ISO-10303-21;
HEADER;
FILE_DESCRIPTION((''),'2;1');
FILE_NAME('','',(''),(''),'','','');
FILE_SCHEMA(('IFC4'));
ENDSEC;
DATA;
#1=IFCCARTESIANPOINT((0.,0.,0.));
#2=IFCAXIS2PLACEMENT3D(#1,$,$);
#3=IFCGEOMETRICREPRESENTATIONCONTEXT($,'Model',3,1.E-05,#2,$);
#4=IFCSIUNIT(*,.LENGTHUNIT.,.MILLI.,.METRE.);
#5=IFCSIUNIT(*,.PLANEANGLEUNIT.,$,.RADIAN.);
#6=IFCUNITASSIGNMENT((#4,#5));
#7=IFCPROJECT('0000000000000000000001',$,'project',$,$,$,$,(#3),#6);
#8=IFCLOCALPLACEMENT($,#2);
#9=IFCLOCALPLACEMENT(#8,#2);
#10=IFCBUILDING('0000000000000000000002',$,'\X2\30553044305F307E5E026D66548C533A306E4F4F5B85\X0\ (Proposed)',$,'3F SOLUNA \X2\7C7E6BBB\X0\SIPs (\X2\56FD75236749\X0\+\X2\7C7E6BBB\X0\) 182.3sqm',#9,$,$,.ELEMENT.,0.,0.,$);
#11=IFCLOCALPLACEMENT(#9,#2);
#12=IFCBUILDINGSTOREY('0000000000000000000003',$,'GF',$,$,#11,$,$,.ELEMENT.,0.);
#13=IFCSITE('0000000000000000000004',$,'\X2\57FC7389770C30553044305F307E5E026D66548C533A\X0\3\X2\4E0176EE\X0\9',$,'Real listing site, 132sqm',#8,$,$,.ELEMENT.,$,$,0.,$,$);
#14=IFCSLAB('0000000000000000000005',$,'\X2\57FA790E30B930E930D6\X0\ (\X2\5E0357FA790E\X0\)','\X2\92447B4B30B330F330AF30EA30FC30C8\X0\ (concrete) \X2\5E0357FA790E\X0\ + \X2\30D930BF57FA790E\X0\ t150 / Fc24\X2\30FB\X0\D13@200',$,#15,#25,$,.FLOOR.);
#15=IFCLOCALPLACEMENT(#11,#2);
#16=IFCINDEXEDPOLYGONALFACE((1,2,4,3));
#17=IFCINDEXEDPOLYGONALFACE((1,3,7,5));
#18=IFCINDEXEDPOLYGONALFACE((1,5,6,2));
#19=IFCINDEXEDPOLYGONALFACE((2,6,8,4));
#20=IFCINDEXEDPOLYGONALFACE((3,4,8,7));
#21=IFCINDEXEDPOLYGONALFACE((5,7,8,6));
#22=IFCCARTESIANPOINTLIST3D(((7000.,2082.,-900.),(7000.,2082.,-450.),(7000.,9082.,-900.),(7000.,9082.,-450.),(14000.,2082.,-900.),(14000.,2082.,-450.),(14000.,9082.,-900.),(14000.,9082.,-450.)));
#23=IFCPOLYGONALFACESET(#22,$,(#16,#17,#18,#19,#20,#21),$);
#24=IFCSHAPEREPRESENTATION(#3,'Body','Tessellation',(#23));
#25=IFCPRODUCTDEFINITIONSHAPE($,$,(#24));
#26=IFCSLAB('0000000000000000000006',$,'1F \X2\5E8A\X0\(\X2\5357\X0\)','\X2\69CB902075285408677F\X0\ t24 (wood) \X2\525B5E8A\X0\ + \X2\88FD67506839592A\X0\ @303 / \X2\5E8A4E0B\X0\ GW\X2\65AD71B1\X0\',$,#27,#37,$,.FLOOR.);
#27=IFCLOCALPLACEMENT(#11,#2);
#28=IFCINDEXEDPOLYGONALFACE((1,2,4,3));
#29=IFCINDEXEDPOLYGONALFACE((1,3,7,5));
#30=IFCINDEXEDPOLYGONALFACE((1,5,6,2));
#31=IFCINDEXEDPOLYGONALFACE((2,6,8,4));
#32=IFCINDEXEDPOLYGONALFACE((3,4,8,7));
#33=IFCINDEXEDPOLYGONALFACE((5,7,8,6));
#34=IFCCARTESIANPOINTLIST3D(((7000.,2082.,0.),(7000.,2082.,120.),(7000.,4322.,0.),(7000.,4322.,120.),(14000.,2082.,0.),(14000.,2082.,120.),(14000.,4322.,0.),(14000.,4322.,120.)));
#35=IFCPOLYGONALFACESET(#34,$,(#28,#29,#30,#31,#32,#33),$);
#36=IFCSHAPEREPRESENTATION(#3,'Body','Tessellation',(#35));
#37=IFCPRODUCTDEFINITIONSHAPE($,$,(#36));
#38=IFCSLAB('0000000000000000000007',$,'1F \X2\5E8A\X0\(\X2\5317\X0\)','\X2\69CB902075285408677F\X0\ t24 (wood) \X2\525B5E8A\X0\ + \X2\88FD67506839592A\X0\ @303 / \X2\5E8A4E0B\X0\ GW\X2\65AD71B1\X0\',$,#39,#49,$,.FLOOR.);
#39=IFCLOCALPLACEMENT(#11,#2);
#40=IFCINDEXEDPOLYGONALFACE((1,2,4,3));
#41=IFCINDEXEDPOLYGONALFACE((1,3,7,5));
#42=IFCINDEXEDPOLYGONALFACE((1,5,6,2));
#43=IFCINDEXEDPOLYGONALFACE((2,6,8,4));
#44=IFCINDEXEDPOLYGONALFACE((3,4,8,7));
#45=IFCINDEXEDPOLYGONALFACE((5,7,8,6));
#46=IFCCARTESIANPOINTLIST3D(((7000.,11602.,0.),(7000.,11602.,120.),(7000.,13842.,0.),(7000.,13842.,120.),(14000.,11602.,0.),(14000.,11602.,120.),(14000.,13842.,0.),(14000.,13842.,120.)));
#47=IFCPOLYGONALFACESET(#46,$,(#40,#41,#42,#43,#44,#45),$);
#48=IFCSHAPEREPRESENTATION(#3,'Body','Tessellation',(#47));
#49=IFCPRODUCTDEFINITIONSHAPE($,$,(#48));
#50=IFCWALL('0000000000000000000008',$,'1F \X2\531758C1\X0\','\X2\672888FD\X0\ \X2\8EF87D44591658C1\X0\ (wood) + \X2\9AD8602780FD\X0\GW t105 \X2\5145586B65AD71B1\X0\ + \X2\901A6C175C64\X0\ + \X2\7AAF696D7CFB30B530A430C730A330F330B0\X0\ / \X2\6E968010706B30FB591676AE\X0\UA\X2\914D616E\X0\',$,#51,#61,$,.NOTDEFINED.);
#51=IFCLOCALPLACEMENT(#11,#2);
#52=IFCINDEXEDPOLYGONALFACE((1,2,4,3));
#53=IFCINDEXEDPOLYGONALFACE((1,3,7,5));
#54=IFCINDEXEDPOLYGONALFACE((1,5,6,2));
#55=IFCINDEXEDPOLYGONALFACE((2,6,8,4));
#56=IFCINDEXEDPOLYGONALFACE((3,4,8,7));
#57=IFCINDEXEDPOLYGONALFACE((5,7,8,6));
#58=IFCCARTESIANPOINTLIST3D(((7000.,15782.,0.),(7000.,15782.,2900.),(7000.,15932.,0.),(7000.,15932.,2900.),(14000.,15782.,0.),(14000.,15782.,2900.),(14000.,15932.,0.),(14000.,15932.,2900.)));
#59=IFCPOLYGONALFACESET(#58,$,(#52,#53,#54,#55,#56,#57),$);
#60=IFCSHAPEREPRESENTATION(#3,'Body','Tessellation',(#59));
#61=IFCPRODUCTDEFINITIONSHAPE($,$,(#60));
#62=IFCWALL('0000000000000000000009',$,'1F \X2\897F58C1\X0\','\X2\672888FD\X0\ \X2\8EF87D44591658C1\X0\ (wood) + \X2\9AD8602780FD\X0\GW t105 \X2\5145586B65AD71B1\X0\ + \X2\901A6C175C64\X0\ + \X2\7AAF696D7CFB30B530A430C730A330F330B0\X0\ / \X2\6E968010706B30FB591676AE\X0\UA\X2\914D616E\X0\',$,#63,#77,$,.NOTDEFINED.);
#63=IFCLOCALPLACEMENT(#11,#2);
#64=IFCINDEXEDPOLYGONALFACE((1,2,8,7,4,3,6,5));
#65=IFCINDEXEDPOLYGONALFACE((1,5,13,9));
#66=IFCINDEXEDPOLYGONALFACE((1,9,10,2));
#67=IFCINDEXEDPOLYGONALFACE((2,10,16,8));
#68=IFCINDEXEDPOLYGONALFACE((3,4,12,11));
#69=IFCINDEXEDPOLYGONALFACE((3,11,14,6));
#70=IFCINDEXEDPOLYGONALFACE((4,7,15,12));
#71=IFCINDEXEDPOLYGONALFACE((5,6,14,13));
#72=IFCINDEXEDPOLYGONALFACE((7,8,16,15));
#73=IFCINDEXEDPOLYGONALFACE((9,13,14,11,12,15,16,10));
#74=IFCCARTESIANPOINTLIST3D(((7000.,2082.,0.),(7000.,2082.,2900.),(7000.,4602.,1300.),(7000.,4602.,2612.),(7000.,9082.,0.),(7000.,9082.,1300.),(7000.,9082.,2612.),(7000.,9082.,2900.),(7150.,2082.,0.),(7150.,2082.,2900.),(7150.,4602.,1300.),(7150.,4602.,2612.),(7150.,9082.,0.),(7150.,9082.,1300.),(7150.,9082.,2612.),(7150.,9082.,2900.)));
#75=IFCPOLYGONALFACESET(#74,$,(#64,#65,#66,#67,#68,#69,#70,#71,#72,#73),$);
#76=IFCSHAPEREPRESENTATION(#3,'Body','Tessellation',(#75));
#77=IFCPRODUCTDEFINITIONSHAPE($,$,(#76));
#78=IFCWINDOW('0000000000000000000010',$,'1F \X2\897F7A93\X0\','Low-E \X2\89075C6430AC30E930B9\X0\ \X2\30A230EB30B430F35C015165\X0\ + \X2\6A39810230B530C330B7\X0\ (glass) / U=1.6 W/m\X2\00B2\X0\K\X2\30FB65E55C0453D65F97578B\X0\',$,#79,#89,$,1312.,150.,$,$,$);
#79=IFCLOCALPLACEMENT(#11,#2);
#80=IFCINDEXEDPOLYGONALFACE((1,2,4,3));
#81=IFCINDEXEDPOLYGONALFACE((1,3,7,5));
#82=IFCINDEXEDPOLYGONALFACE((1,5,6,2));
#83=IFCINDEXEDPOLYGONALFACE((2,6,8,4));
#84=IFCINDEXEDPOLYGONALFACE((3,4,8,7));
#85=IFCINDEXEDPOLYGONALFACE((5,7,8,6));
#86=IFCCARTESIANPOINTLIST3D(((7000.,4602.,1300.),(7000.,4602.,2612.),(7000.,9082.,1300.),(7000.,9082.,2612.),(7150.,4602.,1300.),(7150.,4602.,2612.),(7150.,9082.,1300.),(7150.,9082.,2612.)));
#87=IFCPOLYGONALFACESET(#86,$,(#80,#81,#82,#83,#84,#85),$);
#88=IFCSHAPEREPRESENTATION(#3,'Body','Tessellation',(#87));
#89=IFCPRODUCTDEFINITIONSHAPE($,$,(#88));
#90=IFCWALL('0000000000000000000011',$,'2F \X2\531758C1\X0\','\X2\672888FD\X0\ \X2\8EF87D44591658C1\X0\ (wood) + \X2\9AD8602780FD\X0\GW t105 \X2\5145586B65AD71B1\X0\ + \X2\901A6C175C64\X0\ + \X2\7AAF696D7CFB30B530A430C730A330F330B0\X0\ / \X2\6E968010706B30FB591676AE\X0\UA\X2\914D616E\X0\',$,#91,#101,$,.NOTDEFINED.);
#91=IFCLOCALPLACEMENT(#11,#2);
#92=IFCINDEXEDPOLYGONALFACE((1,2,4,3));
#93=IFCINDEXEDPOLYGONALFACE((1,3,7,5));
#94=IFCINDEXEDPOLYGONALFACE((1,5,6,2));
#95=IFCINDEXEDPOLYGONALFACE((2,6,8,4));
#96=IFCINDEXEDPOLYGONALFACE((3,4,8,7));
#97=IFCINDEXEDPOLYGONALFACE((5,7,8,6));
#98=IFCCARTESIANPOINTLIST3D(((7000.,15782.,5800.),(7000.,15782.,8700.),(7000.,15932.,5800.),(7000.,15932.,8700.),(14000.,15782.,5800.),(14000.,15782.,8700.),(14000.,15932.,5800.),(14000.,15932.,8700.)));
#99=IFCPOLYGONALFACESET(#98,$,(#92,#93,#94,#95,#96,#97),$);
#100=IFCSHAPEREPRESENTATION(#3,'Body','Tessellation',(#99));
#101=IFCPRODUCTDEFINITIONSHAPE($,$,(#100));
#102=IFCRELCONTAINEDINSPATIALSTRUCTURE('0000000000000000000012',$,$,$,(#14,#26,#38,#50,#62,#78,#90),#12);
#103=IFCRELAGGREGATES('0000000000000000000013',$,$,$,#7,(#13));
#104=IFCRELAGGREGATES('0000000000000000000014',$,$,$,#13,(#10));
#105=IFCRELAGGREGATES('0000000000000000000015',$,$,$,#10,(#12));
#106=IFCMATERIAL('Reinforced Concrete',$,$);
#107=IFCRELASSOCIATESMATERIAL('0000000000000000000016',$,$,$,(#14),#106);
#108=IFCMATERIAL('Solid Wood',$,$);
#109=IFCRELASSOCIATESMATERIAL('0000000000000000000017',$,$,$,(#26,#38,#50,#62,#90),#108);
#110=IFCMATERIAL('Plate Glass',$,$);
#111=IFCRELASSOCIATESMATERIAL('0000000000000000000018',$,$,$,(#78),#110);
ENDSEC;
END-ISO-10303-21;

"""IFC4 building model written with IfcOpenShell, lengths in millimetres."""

from ifc_helpers import new_model, si_unit, frame, frame_2d, origin, place, context, project, spatial, rectangle, extrude, material, element, fill, save


model = new_model("IFC4")

# Units and contexts
model_context = context("Model", 3, precision=1e-05, world=origin())
ifc_project = project(units=[si_unit("LENGTHUNIT", "METRE", prefix="MILLI"), si_unit("PLANEANGLEUNIT", "RADIAN")], contexts=[model_context])

# Site, building, storey
site_placement = place(None, origin())
site = spatial("IfcSite", under=ifc_project, at=site_placement, Name="埼玉県さいたま市浦和区3丁目9", ObjectType="Real listing site, 132sqm", CompositionType="ELEMENT", RefElevation=0.0)
building_placement = place(site_placement, origin())
building = spatial("IfcBuilding", under=site, at=building_placement, Name="さいたま市浦和区の住宅 (Proposed)", ObjectType="3F SOLUNA 籾殻SIPs (国産杉+籾殻) 182.3sqm", CompositionType="ELEMENT", ElevationOfRefHeight=0.0, ElevationOfTerrain=0.0)
storey_placement = place(building_placement, origin())
storey = spatial("IfcBuildingStorey", under=building, at=storey_placement, Name="GF", CompositionType="ELEMENT", Elevation=0.0)

# Slabs
ifc_material_1 = material(Name="Reinforced Concrete")
slab_1_placement = place(storey_placement, frame((3500.0, 1041.0, -450.0)))
element("IfcSlab", 1, at=slab_1_placement, inside=storey, material=ifc_material_1, Name="基礎スラブ (布基礎)", Description="鉄筋コンクリート (concrete) 布基礎 + ベタ基礎 t150 / Fc24・D13@200", PredefinedType="FLOOR", context=model_context, shape_type="SweptSolid", body=[
    extrude(rectangle(XDim=7000.0, YDim=7000.0, at=frame_2d((3500.0, 3500.0))), frame((3500.0, 1041.0, -450.0)), (0.0, 0.0, 1.0), 450.0),
])
ifc_material_2 = material(Name="Solid Wood")
slab_2_placement = place(storey_placement, frame((3500.0, 1041.0, 0.0)))
element("IfcSlab", 2, at=slab_2_placement, inside=storey, material=ifc_material_2, Name="1F 床(南)", Description="構造用合板 t24 (wood) 剛床 + 製材根太 @303 / 床下 GW断熱", PredefinedType="FLOOR", context=model_context, shape_type="SweptSolid", body=[
    extrude(rectangle(XDim=7000.0, YDim=2240.0, at=frame_2d((3500.0, 1120.0))), frame((3500.0, 1041.0, 0.0)), (0.0, 0.0, 1.0), 120.0),
])
slab_3_placement = place(storey_placement, frame((3500.0, 5801.0, 0.0)))
element("IfcSlab", 3, at=slab_3_placement, inside=storey, material=ifc_material_2, Name="1F 床(北)", Description="構造用合板 t24 (wood) 剛床 + 製材根太 @303 / 床下 GW断熱", PredefinedType="FLOOR", context=model_context, shape_type="SweptSolid", body=[
    extrude(rectangle(XDim=7000.0, YDim=2240.0, at=frame_2d((3500.0, 1120.0))), frame((3500.0, 5801.0, 0.0)), (0.0, 0.0, 1.0), 120.0),
])

# Shared definitions
ifc_material_3 = material(Name="Plate Glass")

# Wall
wall_1_placement = place(storey_placement, frame((3500.0, 7891.0, 0.0)))
element("IfcWall", 4, at=wall_1_placement, inside=storey, material=ifc_material_2, Name="1F 北壁", Description="木製 軸組外壁 (wood) + 高性能GW t105 充填断熱 + 通気層 + 窯業系サイディング / 準耐火・外皮UA配慮", PredefinedType="NOTDEFINED", context=model_context, shape_type="SweptSolid", body=[
    extrude(rectangle(XDim=7000.0, YDim=150.0, at=frame_2d((3500.0, 75.0))), frame((3500.0, 7891.0, 0.0)), (0.0, 0.0, 1.0), 2900.0),
])

# Wall, opening, window
wall_2_placement = place(storey_placement, frame((3500.0, 1041.0, 0.0)))
wall_2 = element("IfcWall", 5, at=wall_2_placement, inside=storey, material=ifc_material_2, Name="1F 西壁", Description="木製 軸組外壁 (wood) + 高性能GW t105 充填断熱 + 通気層 + 窯業系サイディング / 準耐火・外皮UA配慮", PredefinedType="NOTDEFINED", context=model_context, shape_type="SweptSolid", body=[
    extrude(rectangle(XDim=150.0, YDim=7000.0, at=frame_2d((75.0, 3500.0))), frame((3500.0, 1041.0, 0.0)), (0.0, 0.0, 1.0), 2900.0),
])
opening_1_placement = place(storey_placement, frame((3500.0, 2301.0, 650.0)))
opening_1 = element("IfcOpeningElement", 6, at=opening_1_placement, cuts=wall_2, PredefinedType="NOTDEFINED", context=model_context, shape_type="SweptSolid", body=[
    extrude(rectangle(XDim=150.0, YDim=4480.0, at=frame_2d((75.0, 2240.0))), frame((3500.0, 2301.0, 650.0)), (0.0, 0.0, 1.0), 1312.0),
])
window_1_placement = place(storey_placement, frame((3500.0, 2301.0, 650.0)))
window_1 = element("IfcWindow", 7, at=window_1_placement, inside=storey, material=ifc_material_3, Name="1F 西窓", Description="Low-E 複層ガラス アルゴン封入 + 樹脂サッシ (glass) / U=1.6 W/m²K・日射取得型", OverallHeight=1312.0, OverallWidth=150.0, context=model_context, shape_type="SweptSolid", body=[
    extrude(rectangle(XDim=150.0, YDim=4480.0, at=frame_2d((75.0, 2240.0))), frame((3500.0, 2301.0, 650.0)), (0.0, 0.0, 1.0), 1312.0),
])
fill(opening_1, window_1)

# Wall
wall_3_placement = place(storey_placement, frame((3500.0, 7891.0, 2900.0)))
element("IfcWall", 8, at=wall_3_placement, inside=storey, material=ifc_material_2, Name="2F 北壁", Description="木製 軸組外壁 (wood) + 高性能GW t105 充填断熱 + 通気層 + 窯業系サイディング / 準耐火・外皮UA配慮", PredefinedType="NOTDEFINED", context=model_context, shape_type="SweptSolid", body=[
    extrude(rectangle(XDim=7000.0, YDim=150.0, at=frame_2d((3500.0, 75.0))), frame((3500.0, 7891.0, 2900.0)), (0.0, 0.0, 1.0), 2900.0),
])

save(model, "model.ifc")
